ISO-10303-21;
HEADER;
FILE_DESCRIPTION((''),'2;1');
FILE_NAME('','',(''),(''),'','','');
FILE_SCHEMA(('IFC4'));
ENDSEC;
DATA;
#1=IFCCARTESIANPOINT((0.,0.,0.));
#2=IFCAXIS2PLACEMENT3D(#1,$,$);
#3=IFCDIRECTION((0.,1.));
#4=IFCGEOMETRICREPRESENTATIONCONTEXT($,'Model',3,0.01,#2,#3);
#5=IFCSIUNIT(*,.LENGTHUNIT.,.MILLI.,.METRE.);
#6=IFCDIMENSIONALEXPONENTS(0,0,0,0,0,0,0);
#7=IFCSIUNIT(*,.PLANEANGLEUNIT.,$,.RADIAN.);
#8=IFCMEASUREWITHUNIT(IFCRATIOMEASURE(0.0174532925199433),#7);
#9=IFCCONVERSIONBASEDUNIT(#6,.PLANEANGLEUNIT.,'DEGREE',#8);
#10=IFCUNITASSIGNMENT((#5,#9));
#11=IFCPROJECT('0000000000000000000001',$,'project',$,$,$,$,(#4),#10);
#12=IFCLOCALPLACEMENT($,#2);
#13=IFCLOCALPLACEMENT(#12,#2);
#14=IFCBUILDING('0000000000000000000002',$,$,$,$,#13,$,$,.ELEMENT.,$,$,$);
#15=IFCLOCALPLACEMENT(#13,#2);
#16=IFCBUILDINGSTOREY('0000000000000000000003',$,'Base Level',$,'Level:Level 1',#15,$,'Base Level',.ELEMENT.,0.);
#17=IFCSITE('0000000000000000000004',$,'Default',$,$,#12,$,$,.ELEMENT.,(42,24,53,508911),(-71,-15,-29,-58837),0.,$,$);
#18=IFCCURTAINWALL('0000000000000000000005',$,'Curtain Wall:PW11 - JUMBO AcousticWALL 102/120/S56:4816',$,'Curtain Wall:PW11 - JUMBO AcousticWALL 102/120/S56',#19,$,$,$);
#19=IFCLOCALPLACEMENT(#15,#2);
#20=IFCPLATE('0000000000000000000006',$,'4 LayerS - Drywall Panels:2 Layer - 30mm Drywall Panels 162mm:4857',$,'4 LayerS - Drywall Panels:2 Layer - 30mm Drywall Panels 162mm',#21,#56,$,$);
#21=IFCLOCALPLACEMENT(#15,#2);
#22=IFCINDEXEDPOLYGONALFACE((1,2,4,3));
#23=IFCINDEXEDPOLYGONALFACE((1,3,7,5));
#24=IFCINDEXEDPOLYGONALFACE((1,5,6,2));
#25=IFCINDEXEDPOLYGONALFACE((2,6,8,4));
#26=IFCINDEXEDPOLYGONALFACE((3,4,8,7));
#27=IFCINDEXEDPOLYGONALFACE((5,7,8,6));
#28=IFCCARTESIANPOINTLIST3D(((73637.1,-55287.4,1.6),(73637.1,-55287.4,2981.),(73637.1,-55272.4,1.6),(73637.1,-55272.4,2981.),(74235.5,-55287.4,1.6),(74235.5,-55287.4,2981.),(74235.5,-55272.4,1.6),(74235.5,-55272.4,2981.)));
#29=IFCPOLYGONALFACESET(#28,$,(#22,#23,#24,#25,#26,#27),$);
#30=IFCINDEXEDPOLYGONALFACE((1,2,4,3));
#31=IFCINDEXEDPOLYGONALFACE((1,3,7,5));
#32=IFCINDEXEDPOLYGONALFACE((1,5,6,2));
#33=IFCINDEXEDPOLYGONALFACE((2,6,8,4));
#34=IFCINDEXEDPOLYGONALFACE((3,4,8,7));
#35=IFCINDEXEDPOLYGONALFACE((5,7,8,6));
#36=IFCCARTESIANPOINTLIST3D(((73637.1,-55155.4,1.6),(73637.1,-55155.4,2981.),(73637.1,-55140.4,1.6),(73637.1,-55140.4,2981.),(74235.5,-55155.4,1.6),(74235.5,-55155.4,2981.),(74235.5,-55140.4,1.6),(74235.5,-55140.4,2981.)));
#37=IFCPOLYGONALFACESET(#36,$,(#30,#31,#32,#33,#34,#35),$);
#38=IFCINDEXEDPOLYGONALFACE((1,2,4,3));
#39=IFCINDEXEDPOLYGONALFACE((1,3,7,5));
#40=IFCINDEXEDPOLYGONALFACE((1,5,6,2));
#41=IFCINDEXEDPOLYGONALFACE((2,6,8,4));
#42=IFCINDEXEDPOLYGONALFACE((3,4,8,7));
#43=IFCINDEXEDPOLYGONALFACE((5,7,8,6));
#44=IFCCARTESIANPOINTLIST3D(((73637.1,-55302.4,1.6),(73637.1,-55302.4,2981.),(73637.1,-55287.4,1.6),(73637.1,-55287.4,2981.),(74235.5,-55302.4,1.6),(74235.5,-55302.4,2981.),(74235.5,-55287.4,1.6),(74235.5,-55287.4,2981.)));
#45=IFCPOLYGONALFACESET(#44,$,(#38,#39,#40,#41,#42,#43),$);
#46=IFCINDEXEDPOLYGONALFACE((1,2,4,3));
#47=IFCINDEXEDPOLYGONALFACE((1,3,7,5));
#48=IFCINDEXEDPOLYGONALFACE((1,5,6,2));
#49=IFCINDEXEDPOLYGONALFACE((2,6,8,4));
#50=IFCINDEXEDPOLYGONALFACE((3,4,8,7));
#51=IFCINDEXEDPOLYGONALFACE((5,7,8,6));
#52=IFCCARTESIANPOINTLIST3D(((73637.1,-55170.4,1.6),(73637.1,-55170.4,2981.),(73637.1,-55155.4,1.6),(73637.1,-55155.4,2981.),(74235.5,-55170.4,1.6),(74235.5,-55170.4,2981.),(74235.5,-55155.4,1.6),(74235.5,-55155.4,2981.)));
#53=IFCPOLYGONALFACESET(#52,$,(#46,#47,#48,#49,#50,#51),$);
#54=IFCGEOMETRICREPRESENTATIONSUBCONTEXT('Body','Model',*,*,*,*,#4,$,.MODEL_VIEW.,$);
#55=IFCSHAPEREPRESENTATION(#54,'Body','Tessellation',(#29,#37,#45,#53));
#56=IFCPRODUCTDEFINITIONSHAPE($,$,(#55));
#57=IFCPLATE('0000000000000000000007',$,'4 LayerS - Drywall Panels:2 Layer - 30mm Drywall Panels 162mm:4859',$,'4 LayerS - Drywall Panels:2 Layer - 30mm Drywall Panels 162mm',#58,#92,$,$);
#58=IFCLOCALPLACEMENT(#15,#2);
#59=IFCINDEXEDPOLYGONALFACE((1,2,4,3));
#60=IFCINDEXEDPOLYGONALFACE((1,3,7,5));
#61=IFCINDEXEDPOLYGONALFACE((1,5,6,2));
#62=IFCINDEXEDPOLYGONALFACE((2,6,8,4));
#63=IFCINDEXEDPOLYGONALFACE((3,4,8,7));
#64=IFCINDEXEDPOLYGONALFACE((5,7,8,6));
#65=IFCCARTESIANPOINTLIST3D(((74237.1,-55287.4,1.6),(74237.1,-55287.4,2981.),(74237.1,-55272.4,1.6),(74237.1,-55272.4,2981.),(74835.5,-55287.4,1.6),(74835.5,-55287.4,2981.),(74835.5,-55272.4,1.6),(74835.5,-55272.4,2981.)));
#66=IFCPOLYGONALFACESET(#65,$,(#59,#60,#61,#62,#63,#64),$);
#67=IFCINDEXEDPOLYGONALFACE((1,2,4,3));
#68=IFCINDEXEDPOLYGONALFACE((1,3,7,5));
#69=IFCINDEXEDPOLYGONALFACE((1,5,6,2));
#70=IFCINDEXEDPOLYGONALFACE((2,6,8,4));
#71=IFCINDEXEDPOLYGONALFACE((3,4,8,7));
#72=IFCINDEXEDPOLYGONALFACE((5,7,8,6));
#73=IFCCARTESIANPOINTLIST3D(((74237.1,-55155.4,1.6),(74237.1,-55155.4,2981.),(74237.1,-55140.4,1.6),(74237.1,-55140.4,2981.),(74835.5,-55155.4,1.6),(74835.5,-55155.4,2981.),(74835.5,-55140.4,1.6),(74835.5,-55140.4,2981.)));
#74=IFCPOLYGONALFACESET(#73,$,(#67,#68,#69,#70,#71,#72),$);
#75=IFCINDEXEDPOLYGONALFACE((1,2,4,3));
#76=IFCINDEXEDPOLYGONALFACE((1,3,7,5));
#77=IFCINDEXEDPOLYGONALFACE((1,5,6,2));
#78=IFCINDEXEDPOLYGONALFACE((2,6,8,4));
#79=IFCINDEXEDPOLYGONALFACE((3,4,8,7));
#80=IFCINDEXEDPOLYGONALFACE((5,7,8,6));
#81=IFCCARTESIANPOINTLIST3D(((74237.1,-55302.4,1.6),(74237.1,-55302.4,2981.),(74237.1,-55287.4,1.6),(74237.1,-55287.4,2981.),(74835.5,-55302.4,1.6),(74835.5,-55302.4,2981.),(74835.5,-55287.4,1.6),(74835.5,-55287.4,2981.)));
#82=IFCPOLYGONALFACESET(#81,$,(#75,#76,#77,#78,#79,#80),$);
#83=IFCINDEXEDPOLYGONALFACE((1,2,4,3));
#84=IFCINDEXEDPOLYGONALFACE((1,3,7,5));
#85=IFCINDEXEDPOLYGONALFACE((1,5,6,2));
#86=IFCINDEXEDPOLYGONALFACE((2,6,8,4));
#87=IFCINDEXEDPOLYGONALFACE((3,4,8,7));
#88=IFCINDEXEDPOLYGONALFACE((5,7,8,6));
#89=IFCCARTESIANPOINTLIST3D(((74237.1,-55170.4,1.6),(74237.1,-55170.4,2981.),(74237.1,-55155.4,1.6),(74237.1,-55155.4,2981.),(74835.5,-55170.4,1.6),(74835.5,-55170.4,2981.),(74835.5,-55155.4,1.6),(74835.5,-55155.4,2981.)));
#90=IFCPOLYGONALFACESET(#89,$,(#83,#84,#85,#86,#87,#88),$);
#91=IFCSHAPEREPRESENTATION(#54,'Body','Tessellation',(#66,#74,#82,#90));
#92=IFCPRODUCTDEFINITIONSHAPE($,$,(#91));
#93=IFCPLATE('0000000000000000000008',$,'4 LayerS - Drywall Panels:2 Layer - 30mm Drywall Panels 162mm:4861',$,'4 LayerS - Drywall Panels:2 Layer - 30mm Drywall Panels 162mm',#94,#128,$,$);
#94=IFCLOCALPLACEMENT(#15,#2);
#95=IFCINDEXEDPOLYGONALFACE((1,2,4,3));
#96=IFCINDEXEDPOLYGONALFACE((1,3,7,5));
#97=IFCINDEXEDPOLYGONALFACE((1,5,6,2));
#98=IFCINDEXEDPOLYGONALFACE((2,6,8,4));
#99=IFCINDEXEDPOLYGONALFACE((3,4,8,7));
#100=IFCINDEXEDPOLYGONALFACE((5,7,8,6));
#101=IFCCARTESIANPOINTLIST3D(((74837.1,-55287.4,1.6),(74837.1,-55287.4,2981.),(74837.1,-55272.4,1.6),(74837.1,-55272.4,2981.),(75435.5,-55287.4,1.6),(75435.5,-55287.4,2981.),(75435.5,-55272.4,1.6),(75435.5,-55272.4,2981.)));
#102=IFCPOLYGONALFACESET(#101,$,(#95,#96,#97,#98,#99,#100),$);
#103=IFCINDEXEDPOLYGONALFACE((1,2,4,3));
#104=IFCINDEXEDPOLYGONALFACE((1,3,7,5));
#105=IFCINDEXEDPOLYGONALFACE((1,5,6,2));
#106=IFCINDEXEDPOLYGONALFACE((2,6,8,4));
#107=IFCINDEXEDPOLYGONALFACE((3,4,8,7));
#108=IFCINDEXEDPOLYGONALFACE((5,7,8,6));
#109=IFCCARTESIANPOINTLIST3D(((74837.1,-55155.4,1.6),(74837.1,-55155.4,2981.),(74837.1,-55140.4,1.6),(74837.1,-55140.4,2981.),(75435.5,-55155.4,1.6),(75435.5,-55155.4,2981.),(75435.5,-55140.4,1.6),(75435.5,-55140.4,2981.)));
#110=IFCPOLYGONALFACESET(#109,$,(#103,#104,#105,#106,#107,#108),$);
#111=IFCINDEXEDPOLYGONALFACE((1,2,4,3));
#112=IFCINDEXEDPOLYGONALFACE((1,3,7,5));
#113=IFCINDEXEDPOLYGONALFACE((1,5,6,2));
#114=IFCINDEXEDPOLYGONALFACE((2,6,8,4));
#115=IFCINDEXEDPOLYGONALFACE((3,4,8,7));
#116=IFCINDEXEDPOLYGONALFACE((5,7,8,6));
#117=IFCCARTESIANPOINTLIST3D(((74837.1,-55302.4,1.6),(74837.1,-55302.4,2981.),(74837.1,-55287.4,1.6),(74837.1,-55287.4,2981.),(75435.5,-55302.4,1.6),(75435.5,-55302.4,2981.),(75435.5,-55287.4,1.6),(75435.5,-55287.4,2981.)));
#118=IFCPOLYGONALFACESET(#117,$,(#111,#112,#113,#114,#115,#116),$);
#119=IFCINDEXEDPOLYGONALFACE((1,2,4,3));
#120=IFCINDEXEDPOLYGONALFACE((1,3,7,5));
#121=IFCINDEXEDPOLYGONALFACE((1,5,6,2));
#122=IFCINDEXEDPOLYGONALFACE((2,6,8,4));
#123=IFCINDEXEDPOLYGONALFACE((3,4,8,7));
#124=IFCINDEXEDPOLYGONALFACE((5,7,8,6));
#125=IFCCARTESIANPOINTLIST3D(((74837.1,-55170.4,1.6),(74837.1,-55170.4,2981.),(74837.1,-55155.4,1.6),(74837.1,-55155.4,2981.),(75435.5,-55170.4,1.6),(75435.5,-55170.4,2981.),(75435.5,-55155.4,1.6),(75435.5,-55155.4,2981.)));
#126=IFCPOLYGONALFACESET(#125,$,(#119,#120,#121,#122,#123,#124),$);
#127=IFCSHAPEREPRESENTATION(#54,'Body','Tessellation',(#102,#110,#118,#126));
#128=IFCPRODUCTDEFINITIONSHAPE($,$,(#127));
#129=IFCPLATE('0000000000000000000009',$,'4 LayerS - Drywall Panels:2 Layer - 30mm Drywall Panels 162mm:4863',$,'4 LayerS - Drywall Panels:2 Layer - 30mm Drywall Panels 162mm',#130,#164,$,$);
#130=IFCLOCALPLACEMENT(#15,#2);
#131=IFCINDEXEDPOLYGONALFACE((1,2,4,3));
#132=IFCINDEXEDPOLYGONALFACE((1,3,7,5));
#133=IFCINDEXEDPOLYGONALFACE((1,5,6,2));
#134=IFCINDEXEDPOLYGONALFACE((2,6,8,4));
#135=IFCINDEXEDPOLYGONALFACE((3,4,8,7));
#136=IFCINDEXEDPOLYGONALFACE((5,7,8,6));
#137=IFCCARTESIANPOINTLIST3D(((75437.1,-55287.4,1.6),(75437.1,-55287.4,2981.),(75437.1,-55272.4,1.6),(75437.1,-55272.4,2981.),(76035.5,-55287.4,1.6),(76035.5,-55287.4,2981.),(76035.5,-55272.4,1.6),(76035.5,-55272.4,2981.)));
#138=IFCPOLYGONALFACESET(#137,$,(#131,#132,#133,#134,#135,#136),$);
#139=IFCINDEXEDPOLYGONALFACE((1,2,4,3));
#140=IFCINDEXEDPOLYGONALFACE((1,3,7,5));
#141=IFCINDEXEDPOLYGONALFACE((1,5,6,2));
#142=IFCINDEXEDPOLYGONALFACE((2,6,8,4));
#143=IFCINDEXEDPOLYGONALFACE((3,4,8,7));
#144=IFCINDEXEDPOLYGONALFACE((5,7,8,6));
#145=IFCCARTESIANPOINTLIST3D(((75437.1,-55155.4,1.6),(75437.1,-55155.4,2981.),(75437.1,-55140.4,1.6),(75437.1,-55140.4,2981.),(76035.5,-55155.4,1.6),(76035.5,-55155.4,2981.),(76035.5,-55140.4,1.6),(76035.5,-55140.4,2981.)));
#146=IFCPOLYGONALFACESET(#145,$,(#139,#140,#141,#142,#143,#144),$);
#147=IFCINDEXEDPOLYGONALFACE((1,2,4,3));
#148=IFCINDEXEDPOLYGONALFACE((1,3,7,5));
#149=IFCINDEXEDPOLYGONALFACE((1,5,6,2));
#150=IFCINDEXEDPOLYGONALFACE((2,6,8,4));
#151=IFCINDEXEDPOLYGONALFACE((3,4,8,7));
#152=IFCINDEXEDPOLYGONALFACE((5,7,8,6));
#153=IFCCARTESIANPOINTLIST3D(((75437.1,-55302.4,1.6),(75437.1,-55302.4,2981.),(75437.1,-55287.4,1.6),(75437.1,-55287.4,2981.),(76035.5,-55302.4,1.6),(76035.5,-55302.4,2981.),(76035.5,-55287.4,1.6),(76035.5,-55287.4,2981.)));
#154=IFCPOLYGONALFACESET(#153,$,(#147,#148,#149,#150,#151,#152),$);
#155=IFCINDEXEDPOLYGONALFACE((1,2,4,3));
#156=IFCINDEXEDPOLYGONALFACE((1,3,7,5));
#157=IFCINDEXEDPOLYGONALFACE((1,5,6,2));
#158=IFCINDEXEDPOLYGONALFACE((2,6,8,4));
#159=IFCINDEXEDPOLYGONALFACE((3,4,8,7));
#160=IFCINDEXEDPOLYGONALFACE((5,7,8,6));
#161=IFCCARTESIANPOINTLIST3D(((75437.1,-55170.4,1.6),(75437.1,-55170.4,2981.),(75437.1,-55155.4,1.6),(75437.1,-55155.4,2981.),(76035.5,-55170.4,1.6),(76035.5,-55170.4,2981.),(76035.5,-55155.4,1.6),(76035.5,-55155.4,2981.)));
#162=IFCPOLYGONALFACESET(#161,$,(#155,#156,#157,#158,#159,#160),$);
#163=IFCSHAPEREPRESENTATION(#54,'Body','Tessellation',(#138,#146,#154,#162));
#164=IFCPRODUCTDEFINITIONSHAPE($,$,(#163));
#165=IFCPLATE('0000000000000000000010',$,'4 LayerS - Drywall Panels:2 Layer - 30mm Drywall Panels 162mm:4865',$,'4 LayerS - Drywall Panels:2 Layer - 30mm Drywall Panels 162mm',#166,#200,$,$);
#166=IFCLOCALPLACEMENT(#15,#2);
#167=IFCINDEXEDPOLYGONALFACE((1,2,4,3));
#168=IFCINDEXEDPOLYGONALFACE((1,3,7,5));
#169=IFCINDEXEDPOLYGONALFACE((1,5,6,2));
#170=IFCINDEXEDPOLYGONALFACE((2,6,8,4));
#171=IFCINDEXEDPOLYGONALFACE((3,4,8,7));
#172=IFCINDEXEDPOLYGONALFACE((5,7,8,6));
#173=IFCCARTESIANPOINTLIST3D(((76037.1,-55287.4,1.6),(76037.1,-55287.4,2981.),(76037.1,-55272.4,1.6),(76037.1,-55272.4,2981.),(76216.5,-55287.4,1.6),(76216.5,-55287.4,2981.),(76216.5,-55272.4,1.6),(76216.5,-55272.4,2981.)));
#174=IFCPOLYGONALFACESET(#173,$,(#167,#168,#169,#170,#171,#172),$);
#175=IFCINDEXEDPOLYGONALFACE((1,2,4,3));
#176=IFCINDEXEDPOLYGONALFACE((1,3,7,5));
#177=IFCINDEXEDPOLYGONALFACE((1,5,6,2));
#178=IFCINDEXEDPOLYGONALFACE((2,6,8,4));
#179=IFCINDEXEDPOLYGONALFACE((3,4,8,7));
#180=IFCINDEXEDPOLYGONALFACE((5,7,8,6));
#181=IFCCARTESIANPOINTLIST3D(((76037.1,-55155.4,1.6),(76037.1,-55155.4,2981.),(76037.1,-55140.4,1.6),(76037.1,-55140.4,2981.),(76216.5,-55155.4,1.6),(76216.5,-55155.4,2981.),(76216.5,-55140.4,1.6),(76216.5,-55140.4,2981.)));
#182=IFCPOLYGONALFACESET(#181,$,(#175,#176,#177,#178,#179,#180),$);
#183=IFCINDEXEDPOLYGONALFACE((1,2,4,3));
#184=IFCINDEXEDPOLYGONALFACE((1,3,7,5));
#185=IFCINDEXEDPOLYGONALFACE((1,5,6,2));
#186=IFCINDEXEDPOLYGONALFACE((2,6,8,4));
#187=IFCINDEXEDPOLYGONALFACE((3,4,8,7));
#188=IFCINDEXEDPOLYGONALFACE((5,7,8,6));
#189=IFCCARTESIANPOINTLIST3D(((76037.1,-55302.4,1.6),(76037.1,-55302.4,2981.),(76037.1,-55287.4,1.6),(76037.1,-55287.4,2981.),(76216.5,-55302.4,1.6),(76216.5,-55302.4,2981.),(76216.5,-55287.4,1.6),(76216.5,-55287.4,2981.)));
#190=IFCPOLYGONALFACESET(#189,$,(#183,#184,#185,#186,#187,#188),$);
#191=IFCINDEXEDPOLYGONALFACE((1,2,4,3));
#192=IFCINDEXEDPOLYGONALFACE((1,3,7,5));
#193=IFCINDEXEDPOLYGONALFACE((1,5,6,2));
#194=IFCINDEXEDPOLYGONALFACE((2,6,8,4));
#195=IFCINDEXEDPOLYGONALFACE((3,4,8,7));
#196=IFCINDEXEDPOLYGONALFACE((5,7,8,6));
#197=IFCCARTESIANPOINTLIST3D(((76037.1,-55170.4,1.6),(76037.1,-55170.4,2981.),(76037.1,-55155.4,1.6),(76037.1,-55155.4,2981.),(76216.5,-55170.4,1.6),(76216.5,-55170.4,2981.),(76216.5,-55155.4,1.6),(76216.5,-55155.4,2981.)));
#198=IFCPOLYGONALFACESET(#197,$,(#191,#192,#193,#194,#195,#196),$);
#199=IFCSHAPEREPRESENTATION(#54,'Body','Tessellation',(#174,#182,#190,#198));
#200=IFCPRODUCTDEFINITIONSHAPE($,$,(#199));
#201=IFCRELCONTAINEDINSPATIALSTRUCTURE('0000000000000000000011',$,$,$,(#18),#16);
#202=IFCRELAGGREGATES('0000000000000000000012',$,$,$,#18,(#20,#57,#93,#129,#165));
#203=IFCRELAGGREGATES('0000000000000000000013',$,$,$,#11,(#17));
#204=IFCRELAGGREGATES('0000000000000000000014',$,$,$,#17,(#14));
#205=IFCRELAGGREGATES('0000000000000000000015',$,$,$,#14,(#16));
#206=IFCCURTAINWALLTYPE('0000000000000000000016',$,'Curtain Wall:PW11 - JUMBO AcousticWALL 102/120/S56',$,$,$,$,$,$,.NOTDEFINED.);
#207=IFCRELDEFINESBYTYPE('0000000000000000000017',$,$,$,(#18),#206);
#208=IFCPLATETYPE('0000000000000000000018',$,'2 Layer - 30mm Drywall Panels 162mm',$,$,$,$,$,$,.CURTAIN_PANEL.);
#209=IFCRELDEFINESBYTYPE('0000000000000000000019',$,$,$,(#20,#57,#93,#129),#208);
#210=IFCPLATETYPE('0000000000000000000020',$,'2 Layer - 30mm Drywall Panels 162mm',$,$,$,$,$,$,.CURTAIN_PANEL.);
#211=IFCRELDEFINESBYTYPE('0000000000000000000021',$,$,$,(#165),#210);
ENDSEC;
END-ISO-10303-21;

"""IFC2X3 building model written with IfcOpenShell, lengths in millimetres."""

from ifc_helpers import new_model, entity, si_unit, converted_unit, direction, frame, frame_2d, origin, origin_2d_with_axis, place, context, subcontext, project, spatial, rectangle, extrude, source, transform, mapped, type_object, type_shapes, element, aggregate, save


model = new_model("IFC2X3")

# Units and contexts
model_context = context("Model", 3, precision=0.01, world=origin(), true_north=direction((0.0, 1.0)))
body_context = subcontext(model_context, "Body", "Model", "MODEL_VIEW")
ifc_project = project(units=[si_unit("LENGTHUNIT", "METRE", prefix="MILLI"), converted_unit("PLANEANGLEUNIT", "DEGREE", entity("IfcRatioMeasure", 0.0174532925199433), si_unit("PLANEANGLEUNIT", "RADIAN"), dimensions=[0, 0, 0, 0, 0, 0, 0])], contexts=[model_context])

# Site, building, storey
site_placement = place(None, origin())
site = spatial("IfcSite", under=ifc_project, at=site_placement, Name="Default", CompositionType="ELEMENT", RefLatitude=(42, 24, 53, 508911), RefLongitude=(-71, -15, -29, -58837), RefElevation=0.0)
building_placement = place(site_placement, origin())
building = spatial("IfcBuilding", under=site, at=building_placement, CompositionType="ELEMENT")
storey_placement = place(building_placement, origin())
storey = spatial("IfcBuildingStorey", under=building, at=storey_placement, Name="Base Level", ObjectType="Level:Level 1", LongName="Base Level", CompositionType="ELEMENT", Elevation=0.0)

# Curtain wall, plates
curtain_wall_type = type_object("IfcCurtainWallType", Name="Curtain Wall:PW11 - JUMBO AcousticWALL 102/120/S56", PredefinedType="NOTDEFINED")
curtain_wall_placement = place(building_placement, origin())
curtain_wall = element("IfcCurtainWall", 1, at=curtain_wall_placement, inside=storey, type_object=curtain_wall_type, Name="Curtain Wall:PW11 - JUMBO AcousticWALL 102/120/S56:4816", ObjectType="Curtain Wall:PW11 - JUMBO AcousticWALL 102/120/S56")
plate_type_1 = type_object("IfcPlateType", Name="2 Layer - 30mm Drywall Panels 162mm", PredefinedType="CURTAIN_PANEL")
shared_shape_1 = source(origin(), body_context, "Body", "SweptSolid", [
    extrude(rectangle(XDim=15.0, YDim=598.4, at=origin_2d_with_axis()), frame((0.0, -58.5, 0.0), z_axis=(0.0, 0.0, 1.0), x_axis=(0.0, 1.0, 0.0)), (0.0, 0.0, 1.0), 2979.4),
    extrude(rectangle(XDim=15.0, YDim=598.4, at=frame_2d((0.0, 0.0), x_axis=(1.0, 0.0))), frame((0.0, 73.5, 0.0), z_axis=(0.0, 0.0, 1.0), x_axis=(0.0, 1.0, 0.0)), (0.0, 0.0, 1.0), 2979.4),
    extrude(rectangle(XDim=598.4, YDim=15.0, at=origin_2d_with_axis()), frame((0.0, -73.5, 0.0), z_axis=(0.0, 0.0, 1.0), x_axis=(-1.0, 0.0, 0.0)), (0.0, 0.0, 1.0), 2979.4),
    extrude(rectangle(XDim=15.0, YDim=598.4, at=frame_2d((0.0, 0.0), x_axis=(1.0, 0.0))), frame((0.0, 58.5, 0.0), z_axis=(0.0, 0.0, 1.0), x_axis=(0.0, 1.0, 0.0)), (0.0, 0.0, 1.0), 2979.4),
])
type_shapes(plate_type_1, [shared_shape_1])
plate_1_placement = place(curtain_wall_placement, frame((73936.3, -55221.4, 1.6)))
plate_1 = element("IfcPlate", 2, at=plate_1_placement, type_object=plate_type_1, Name="4 LayerS - Drywall Panels:2 Layer - 30mm Drywall Panels 162mm:4857", ObjectType="4 LayerS - Drywall Panels:2 Layer - 30mm Drywall Panels 162mm", context=body_context, shape_type="MappedRepresentation", body=[
    mapped(shared_shape_1, transform((0.0, 0.0, 0.0), scale=1.0)),
])
plate_2_placement = place(curtain_wall_placement, frame((74536.3, -55221.4, 1.6)))
plate_2 = element("IfcPlate", 3, at=plate_2_placement, type_object=plate_type_1, Name="4 LayerS - Drywall Panels:2 Layer - 30mm Drywall Panels 162mm:4859", ObjectType="4 LayerS - Drywall Panels:2 Layer - 30mm Drywall Panels 162mm", context=body_context, shape_type="MappedRepresentation", body=[
    mapped(shared_shape_1, transform((0.0, 0.0, 0.0), scale=1.0)),
])
plate_3_placement = place(curtain_wall_placement, frame((75136.3, -55221.4, 1.6)))
plate_3 = element("IfcPlate", 4, at=plate_3_placement, type_object=plate_type_1, Name="4 LayerS - Drywall Panels:2 Layer - 30mm Drywall Panels 162mm:4861", ObjectType="4 LayerS - Drywall Panels:2 Layer - 30mm Drywall Panels 162mm", context=body_context, shape_type="MappedRepresentation", body=[
    mapped(shared_shape_1, transform((0.0, 0.0, 0.0), scale=1.0)),
])
plate_4_placement = place(curtain_wall_placement, frame((75736.3, -55221.4, 1.6)))
plate_4 = element("IfcPlate", 5, at=plate_4_placement, type_object=plate_type_1, Name="4 LayerS - Drywall Panels:2 Layer - 30mm Drywall Panels 162mm:4863", ObjectType="4 LayerS - Drywall Panels:2 Layer - 30mm Drywall Panels 162mm", context=body_context, shape_type="MappedRepresentation", body=[
    mapped(shared_shape_1, transform((0.0, 0.0, 0.0), scale=1.0)),
])
plate_type_2 = type_object("IfcPlateType", Name="2 Layer - 30mm Drywall Panels 162mm", PredefinedType="CURTAIN_PANEL")
shared_shape_2 = source(origin(), body_context, "Body", "SweptSolid", [
    extrude(rectangle(XDim=15.0, YDim=179.4, at=origin_2d_with_axis()), frame((0.0, -58.5, 0.0), z_axis=(0.0, 0.0, 1.0), x_axis=(0.0, 1.0, 0.0)), (0.0, 0.0, 1.0), 2979.4),
    extrude(rectangle(XDim=15.0, YDim=179.4, at=origin_2d_with_axis()), frame((0.0, 73.5, 0.0), z_axis=(0.0, 0.0, 1.0), x_axis=(0.0, 1.0, 0.0)), (0.0, 0.0, 1.0), 2979.4),
    extrude(rectangle(XDim=179.4, YDim=15.0, at=origin_2d_with_axis()), frame((0.0, -73.5, 0.0), z_axis=(0.0, 0.0, 1.0), x_axis=(-1.0, 0.0, 0.0)), (0.0, 0.0, 1.0), 2979.4),
    extrude(rectangle(XDim=15.0, YDim=179.4, at=frame_2d((0.0, 0.0), x_axis=(1.0, 0.0))), frame((0.0, 58.5, 0.0), z_axis=(0.0, 0.0, 1.0), x_axis=(0.0, 1.0, 0.0)), (0.0, 0.0, 1.0), 2979.4),
])
type_shapes(plate_type_2, [shared_shape_2])
plate_5_placement = place(curtain_wall_placement, frame((76126.8, -55221.4, 1.6)))
plate_5 = element("IfcPlate", 6, at=plate_5_placement, type_object=plate_type_2, Name="4 LayerS - Drywall Panels:2 Layer - 30mm Drywall Panels 162mm:4865", ObjectType="4 LayerS - Drywall Panels:2 Layer - 30mm Drywall Panels 162mm", context=body_context, shape_type="MappedRepresentation", body=[
    mapped(shared_shape_2, transform((0.0, 0.0, 0.0), scale=1.0)),
])
aggregate(curtain_wall, [plate_1, plate_2, plate_3, plate_4, plate_5])

save(model, "model.ifc")
